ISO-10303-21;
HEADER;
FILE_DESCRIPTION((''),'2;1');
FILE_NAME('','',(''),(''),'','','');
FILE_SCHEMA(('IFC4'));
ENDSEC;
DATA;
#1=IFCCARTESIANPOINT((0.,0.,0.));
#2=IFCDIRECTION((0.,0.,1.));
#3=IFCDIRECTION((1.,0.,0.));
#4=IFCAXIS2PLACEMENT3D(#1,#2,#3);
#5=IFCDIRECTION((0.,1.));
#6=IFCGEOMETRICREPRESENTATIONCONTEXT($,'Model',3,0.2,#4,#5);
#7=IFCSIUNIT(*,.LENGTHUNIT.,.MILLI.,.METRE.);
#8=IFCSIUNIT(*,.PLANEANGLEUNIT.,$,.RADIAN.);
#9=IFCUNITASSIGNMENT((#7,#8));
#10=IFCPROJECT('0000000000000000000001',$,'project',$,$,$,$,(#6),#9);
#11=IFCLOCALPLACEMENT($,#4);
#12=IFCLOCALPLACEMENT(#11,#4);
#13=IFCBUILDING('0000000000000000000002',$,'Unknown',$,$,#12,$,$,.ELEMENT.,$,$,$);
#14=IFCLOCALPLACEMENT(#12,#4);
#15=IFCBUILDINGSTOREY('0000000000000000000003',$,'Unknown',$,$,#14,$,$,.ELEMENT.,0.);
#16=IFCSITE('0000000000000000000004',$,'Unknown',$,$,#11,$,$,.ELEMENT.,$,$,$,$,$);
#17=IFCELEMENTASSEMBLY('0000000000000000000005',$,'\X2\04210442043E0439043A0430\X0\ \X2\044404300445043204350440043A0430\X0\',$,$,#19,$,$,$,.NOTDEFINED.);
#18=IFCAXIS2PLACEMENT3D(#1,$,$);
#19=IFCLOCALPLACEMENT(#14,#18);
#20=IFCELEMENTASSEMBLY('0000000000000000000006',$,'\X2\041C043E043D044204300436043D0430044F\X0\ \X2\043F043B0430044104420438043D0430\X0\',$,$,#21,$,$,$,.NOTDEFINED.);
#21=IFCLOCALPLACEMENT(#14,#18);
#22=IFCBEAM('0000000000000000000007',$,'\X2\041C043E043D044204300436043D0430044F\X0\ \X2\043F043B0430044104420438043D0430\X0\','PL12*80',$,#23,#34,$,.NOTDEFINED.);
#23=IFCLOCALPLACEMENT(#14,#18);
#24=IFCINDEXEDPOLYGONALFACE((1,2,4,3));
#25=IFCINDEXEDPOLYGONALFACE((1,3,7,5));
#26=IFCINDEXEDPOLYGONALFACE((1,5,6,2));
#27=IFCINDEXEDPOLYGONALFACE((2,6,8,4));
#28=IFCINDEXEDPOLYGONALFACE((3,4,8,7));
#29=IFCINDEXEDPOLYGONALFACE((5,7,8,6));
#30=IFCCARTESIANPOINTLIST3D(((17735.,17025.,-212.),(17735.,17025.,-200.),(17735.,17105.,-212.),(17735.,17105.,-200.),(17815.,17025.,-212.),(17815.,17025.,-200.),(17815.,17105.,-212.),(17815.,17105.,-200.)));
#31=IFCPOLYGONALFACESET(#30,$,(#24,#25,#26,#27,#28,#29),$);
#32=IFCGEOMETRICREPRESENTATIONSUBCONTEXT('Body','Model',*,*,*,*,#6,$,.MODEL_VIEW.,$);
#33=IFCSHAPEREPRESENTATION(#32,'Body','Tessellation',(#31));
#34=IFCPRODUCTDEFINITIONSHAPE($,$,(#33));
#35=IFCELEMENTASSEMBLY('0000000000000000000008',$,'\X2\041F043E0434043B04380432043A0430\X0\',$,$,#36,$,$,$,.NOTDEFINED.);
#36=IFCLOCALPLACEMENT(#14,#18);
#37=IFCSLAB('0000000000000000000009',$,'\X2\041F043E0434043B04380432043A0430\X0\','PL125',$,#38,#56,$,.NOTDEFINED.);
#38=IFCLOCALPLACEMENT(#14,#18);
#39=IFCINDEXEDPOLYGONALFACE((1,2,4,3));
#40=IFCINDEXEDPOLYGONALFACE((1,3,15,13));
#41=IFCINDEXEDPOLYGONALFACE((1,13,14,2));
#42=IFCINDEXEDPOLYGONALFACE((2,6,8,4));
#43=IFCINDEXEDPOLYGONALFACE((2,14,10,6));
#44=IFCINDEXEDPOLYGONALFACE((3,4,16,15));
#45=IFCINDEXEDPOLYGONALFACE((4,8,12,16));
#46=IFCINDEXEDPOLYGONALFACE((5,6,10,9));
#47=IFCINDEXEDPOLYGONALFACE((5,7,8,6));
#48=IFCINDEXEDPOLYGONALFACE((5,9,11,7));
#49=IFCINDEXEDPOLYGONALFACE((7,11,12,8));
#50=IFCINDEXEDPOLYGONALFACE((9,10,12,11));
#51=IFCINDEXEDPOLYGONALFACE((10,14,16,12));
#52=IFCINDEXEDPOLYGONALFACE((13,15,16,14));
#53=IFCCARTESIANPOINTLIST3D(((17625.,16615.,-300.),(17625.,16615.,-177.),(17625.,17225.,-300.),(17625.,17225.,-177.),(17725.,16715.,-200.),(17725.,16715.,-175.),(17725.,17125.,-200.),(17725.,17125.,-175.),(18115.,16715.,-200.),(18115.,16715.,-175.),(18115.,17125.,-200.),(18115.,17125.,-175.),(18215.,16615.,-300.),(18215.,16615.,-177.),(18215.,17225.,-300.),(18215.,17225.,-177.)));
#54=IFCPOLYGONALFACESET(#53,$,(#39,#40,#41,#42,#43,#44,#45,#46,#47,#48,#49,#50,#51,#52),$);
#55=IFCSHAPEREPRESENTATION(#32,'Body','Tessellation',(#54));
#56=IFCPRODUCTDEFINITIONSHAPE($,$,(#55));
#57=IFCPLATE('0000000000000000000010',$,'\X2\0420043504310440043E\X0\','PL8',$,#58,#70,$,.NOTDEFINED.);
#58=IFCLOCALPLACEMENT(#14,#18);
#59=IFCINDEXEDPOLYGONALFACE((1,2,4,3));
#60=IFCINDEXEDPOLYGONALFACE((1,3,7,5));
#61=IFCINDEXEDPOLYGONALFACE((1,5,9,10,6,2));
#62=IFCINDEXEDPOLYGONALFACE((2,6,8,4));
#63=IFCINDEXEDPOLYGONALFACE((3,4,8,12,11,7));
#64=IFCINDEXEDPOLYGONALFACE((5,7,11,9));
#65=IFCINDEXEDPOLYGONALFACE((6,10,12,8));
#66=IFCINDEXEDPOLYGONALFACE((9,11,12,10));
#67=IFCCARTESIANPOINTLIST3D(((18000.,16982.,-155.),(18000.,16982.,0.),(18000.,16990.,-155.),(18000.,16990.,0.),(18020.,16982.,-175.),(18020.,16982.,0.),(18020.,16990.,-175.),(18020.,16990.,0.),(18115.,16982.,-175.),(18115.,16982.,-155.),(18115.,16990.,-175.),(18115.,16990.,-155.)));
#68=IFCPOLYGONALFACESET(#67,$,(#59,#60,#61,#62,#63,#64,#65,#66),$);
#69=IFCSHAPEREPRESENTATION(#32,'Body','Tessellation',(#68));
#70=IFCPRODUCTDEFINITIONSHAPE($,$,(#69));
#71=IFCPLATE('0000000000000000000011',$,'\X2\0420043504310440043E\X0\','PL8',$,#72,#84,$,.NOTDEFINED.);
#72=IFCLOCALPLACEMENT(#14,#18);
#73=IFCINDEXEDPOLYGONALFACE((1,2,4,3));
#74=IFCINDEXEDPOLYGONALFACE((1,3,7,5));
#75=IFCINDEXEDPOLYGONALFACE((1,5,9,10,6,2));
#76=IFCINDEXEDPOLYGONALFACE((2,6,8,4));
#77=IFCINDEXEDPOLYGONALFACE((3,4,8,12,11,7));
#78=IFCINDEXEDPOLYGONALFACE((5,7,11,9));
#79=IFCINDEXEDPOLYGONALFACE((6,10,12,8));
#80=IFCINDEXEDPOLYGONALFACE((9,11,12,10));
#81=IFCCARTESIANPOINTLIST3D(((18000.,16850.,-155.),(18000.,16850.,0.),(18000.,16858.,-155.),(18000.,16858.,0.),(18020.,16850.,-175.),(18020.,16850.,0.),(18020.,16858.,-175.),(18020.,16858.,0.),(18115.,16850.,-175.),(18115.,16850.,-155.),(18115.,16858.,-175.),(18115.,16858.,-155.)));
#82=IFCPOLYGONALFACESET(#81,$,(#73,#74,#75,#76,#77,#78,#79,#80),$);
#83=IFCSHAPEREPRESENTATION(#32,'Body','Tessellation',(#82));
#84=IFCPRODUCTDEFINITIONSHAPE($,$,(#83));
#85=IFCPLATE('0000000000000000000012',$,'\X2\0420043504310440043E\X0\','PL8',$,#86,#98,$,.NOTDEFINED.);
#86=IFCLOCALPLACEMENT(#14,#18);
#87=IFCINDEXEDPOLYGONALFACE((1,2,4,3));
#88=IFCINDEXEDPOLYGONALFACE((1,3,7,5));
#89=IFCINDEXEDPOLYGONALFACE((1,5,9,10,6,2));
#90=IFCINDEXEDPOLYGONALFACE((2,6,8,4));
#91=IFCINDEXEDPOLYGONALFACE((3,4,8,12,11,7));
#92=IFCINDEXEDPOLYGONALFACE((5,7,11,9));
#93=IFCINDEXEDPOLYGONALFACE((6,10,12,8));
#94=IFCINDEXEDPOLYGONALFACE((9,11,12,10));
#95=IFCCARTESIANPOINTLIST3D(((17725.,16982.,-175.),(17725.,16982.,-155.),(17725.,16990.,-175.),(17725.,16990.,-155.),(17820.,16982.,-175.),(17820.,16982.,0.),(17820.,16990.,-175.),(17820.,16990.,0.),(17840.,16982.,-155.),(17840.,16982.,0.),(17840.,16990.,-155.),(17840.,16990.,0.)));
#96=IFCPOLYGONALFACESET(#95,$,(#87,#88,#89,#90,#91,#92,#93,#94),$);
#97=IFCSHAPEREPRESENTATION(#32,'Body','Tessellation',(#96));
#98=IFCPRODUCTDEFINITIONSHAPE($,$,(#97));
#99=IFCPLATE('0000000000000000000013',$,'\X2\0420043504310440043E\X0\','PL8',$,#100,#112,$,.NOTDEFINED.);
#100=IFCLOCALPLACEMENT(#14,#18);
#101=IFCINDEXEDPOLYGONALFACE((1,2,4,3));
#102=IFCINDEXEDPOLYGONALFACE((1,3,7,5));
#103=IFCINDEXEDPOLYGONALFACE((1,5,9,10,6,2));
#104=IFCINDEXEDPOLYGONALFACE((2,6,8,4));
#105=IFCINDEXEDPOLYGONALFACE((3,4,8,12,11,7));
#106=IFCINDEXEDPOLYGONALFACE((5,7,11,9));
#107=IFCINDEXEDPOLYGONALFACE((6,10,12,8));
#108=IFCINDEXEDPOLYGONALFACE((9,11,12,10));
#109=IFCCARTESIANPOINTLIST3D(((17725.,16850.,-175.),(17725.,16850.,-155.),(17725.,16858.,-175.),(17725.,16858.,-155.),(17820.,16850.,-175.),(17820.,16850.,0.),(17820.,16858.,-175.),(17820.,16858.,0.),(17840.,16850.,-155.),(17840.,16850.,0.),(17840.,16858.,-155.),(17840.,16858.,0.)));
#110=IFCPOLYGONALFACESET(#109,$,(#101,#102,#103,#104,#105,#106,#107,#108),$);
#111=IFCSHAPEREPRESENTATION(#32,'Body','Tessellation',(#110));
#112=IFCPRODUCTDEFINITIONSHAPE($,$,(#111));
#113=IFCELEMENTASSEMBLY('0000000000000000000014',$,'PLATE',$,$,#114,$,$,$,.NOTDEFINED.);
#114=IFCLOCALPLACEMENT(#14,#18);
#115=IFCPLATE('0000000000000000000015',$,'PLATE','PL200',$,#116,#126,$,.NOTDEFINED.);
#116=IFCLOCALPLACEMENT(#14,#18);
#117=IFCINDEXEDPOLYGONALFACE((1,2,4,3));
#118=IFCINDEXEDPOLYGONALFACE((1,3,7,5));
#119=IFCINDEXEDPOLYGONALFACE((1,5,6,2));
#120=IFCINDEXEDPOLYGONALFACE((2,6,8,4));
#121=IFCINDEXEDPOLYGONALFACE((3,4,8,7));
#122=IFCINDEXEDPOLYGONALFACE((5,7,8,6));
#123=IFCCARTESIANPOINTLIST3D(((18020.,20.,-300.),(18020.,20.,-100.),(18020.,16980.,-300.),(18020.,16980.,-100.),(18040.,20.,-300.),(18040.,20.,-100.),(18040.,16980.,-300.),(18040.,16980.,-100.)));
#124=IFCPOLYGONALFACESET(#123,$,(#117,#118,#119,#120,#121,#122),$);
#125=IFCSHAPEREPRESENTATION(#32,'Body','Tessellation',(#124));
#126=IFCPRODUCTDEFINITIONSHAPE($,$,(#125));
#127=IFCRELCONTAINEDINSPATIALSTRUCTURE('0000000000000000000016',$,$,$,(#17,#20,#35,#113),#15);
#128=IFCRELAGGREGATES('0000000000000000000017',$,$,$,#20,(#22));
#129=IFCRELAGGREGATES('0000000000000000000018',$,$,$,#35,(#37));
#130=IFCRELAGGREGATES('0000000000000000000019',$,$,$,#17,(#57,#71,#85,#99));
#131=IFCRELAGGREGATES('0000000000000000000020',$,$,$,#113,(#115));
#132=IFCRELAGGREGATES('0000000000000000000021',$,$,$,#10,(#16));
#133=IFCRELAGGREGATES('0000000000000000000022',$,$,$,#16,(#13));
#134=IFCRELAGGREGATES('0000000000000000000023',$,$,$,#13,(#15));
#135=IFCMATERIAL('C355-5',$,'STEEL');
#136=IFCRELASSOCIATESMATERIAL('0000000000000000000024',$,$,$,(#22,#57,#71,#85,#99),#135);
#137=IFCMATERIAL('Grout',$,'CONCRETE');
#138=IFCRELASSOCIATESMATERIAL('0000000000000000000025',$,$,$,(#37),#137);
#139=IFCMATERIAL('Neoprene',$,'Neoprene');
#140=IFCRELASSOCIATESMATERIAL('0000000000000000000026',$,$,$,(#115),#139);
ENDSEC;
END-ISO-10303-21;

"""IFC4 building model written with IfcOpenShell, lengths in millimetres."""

from ifc_helpers import new_model, si_unit, direction, frame, origin_with_axes, place, context, subcontext, project, spatial, line, indexed_curve, outline, extrude, material, element, aggregate, save


model = new_model("IFC4")

# Units and contexts
model_context = context("Model", 3, precision=0.2, world=origin_with_axes(), true_north=direction((0.0, 1.0)))
body_context = subcontext(model_context, "Body", "Model", "MODEL_VIEW")
ifc_project = project(units=[si_unit("LENGTHUNIT", "METRE", prefix="MILLI"), si_unit("PLANEANGLEUNIT", "RADIAN")], contexts=[model_context])

# Site, building, storey
site_placement = place(None, origin_with_axes())
site = spatial("IfcSite", under=ifc_project, at=site_placement, Name="Unknown", CompositionType="ELEMENT")
building_placement = place(site_placement, origin_with_axes())
building = spatial("IfcBuilding", under=site, at=building_placement, Name="Unknown", CompositionType="ELEMENT")
storey_placement = place(building_placement, origin_with_axes())
storey = spatial("IfcBuildingStorey", under=building, at=storey_placement, Name="Unknown", CompositionType="ELEMENT", Elevation=0.0)

# Shared definitions
ifc_material_1 = material(Name="C355-5", Category="STEEL")

# Element assembly
assembly_1_placement = place(storey_placement, frame((17920.0, 16920.0, -200.0), z_axis=(0.0, -1.0, 0.0), x_axis=(0.0, 0.0, 1.0)))
assembly_1 = element("IfcElementAssembly", 1, at=assembly_1_placement, inside=storey, Name="Стойка фахверка", PredefinedType="NOTDEFINED")

# Element assembly, beam
assembly_2_placement = place(storey_placement, frame((17735.0, 17065.0, -206.0), z_axis=(0.0, 0.0, -1.0), x_axis=(1.0, 0.0, 0.0)))
assembly_2 = element("IfcElementAssembly", 2, at=assembly_2_placement, inside=storey, Name="Монтажная пластина", PredefinedType="NOTDEFINED")
beam_1_placement = place(assembly_2_placement, origin_with_axes())
beam_1 = element("IfcBeam", 3, at=beam_1_placement, material=ifc_material_1, Name="Монтажная пластина", Description="PL12*80", PredefinedType="NOTDEFINED", context=body_context, shape_type="SolidModel", body=[
    extrude(outline(indexed_curve([(-6.0, -40.0), (6.0, -40.0), (6.0, 40.0), (-6.0, 40.0)], segments=[line(1, 2, 3, 4, 1)])), frame((0.0, 0.0, 0.0), z_axis=(-1.0, 0.0, 0.0), x_axis=(0.0, 0.0, 1.0)), (0.0, 0.0, -1.0), 80.0),
])
aggregate(assembly_2, [beam_1])

# Element assembly, slab, voiding features
assembly_3_placement = place(storey_placement, frame((18215.0, 16615.0, -237.5), z_axis=(0.0, 0.0, -1.0), x_axis=(-1.0, 0.0, 0.0)))
assembly_3 = element("IfcElementAssembly", 4, at=assembly_3_placement, inside=storey, Name="Подливка", PredefinedType="NOTDEFINED")
ifc_material_2 = material(Name="Grout", Category="CONCRETE")
slab_placement = place(assembly_3_placement, origin_with_axes())
slab = element("IfcSlab", 5, at=slab_placement, material=ifc_material_2, Name="Подливка", Description="PL125", PredefinedType="NOTDEFINED", context=body_context, shape_type="SolidModel", body=[
    extrude(outline(indexed_curve([(0.0, 0.0), (590.0, 0.0), (590.0, 610.0), (0.0, 610.0)], segments=[line(1, 2, 3, 4, 1)])), frame((0.0, 0.0, 62.5), z_axis=(0.0, 0.0, 1.0), x_axis=(1.0, 0.0, 0.0)), (0.0, 0.0, -1.0), 125.0),
])
voiding_feature_1_placement = place(slab_placement, frame((295.0, 0.0, -62.5), z_axis=(1.0, 0.0, 0.0), x_axis=(0.0, 1.0, 0.0)))
element("IfcVoidingFeature", 6, at=voiding_feature_1_placement, cuts=slab, Name="PLATE", PredefinedType="HOLE", context=body_context, shape_type="SolidModel", body=[
    extrude(outline(indexed_curve([(0.0, 0.0), (100.0, 0.0), (0.0, 2.0)], segments=[line(1, 2, 3, 1)])), frame((0.0, 0.0, 307.0), z_axis=(0.0, 0.0, 1.0), x_axis=(1.0, 0.0, 0.0)), (0.0, 0.0, -1.0), 614.0),
])
voiding_feature_2_placement = place(slab_placement, frame((295.0, 610.0, -62.5), z_axis=(-1.0, 0.0, 0.0), x_axis=(0.0, -1.0, 0.0)))
element("IfcVoidingFeature", 7, at=voiding_feature_2_placement, cuts=slab, Name="PLATE", PredefinedType="HOLE", context=body_context, shape_type="SolidModel", body=[
    extrude(outline(indexed_curve([(0.0, 0.0), (100.0, 0.0), (0.0, 2.0)], segments=[line(1, 2, 3, 1)])), frame((0.0, 0.0, 307.0), z_axis=(0.0, 0.0, 1.0), x_axis=(1.0, 0.0, 0.0)), (0.0, 0.0, -1.0), 614.0),
])
voiding_feature_3_placement = place(slab_placement, frame((590.0, 305.0, -62.5), z_axis=(0.0, 1.0, 0.0), x_axis=(-1.0, 0.0, 0.0)))
element("IfcVoidingFeature", 8, at=voiding_feature_3_placement, cuts=slab, Name="PLATE", PredefinedType="HOLE", context=body_context, shape_type="SolidModel", body=[
    extrude(outline(indexed_curve([(0.0, 0.0), (100.0, 0.0), (0.0, 2.0)], segments=[line(1, 2, 3, 1)])), frame((0.0, 0.0, 317.0), z_axis=(0.0, 0.0, 1.0), x_axis=(1.0, 0.0, 0.0)), (0.0, 0.0, -1.0), 634.0),
])
voiding_feature_4_placement = place(slab_placement, frame((0.0, 305.0, -62.5), z_axis=(0.0, -1.0, 0.0), x_axis=(1.0, 0.0, 0.0)))
element("IfcVoidingFeature", 9, at=voiding_feature_4_placement, cuts=slab, Name="PLATE", PredefinedType="HOLE", context=body_context, shape_type="SolidModel", body=[
    extrude(outline(indexed_curve([(0.0, 0.0), (100.0, 0.0), (0.0, 2.0)], segments=[line(1, 2, 3, 1)])), frame((0.0, 0.0, 317.0), z_axis=(0.0, 0.0, 1.0), x_axis=(1.0, 0.0, 0.0)), (0.0, 0.0, -1.0), 634.0),
])
voiding_feature_5_placement = place(slab_placement, frame((295.0, 510.0, -50.0), z_axis=(0.0, 0.0, 1.0), x_axis=(0.0, -1.0, 0.0)))
element("IfcVoidingFeature", 10, at=voiding_feature_5_placement, cuts=slab, Name="Пластина", PredefinedType="HOLE", context=body_context, shape_type="SolidModel", body=[
    extrude(outline(indexed_curve([(-12.5, -195.0), (12.5, -195.0), (12.5, 195.0), (-12.5, 195.0)], segments=[line(1, 2, 3, 4, 1)])), frame((0.0, 0.0, 0.0), z_axis=(-1.0, 0.0, 0.0), x_axis=(0.0, 0.0, 1.0)), (0.0, 0.0, -1.0), 410.0),
])
aggregate(assembly_3, [slab])

# Plates
plate_1_placement = place(assembly_1_placement, frame((25.0, -80.0, -66.0), z_axis=(0.0, 0.0, 1.0), x_axis=(0.0, -1.0, 0.0)))
plate_1 = element("IfcPlate", 11, at=plate_1_placement, material=ifc_material_1, Name="Ребро", Description="PL8", PredefinedType="NOTDEFINED", context=body_context, shape_type="SolidModel", body=[
    extrude(outline(indexed_curve([(0.0, 20.0), (20.0, 0.0), (115.0, 0.0), (115.0, 20.0), (20.0, 175.0), (0.0, 175.0)], segments=[line(1, 2, 3, 4, 5, 6, 1)])), frame((0.0, 0.0, 4.0), z_axis=(0.0, 0.0, 1.0), x_axis=(1.0, 0.0, 0.0)), (0.0, 0.0, -1.0), 8.0),
])
plate_2_placement = place(assembly_1_placement, frame((25.0, -80.0, 66.0), z_axis=(0.0, 0.0, 1.0), x_axis=(0.0, -1.0, 0.0)))
plate_2 = element("IfcPlate", 12, at=plate_2_placement, material=ifc_material_1, Name="Ребро", Description="PL8", PredefinedType="NOTDEFINED", context=body_context, shape_type="SolidModel", body=[
    extrude(outline(indexed_curve([(0.0, 20.0), (20.0, 0.0), (115.0, 0.0), (115.0, 20.0), (20.0, 175.0), (0.0, 175.0)], segments=[line(1, 2, 3, 4, 5, 6, 1)])), frame((0.0, 0.0, 4.0), z_axis=(0.0, 0.0, 1.0), x_axis=(1.0, 0.0, 0.0)), (0.0, 0.0, -1.0), 8.0),
])
plate_3_placement = place(assembly_1_placement, frame((25.0, 195.0, -66.0), z_axis=(0.0, 0.0, 1.0), x_axis=(0.0, -1.0, 0.0)))
plate_3 = element("IfcPlate", 13, at=plate_3_placement, material=ifc_material_1, Name="Ребро", Description="PL8", PredefinedType="NOTDEFINED", context=body_context, shape_type="SolidModel", body=[
    extrude(outline(indexed_curve([(0.0, 0.0), (95.0, 0.0), (115.0, 20.0), (115.0, 175.0), (95.0, 175.0), (0.0, 20.0)], segments=[line(1, 2, 3, 4, 5, 6, 1)])), frame((0.0, 0.0, 4.0), z_axis=(0.0, 0.0, 1.0), x_axis=(1.0, 0.0, 0.0)), (0.0, 0.0, -1.0), 8.0),
])
plate_4_placement = place(assembly_1_placement, frame((25.0, 195.0, 66.0), z_axis=(0.0, 0.0, 1.0), x_axis=(0.0, -1.0, 0.0)))
plate_4 = element("IfcPlate", 14, at=plate_4_placement, material=ifc_material_1, Name="Ребро", Description="PL8", PredefinedType="NOTDEFINED", context=body_context, shape_type="SolidModel", body=[
    extrude(outline(indexed_curve([(0.0, 0.0), (95.0, 0.0), (115.0, 20.0), (115.0, 175.0), (95.0, 175.0), (0.0, 20.0)], segments=[line(1, 2, 3, 4, 5, 6, 1)])), frame((0.0, 0.0, 4.0), z_axis=(0.0, 0.0, 1.0), x_axis=(1.0, 0.0, 0.0)), (0.0, 0.0, -1.0), 8.0),
])
aggregate(assembly_1, [plate_1, plate_2, plate_3, plate_4])

# Element assembly, plate
assembly_4_placement = place(storey_placement, frame((20.0, 16980.0, -200.0), z_axis=(0.0, 0.0, 1.0), x_axis=(0.0, -1.0, 0.0)))
assembly_4 = element("IfcElementAssembly", 15, at=assembly_4_placement, inside=storey, Name="PLATE", PredefinedType="NOTDEFINED")
ifc_material_3 = material(Name="Neoprene", Category="Neoprene")
plate_5_placement = place(assembly_4_placement, frame((0.0, 18000.0, 0.0), z_axis=(0.0, 0.0, 1.0), x_axis=(1.0, 0.0, 0.0)))
plate_5 = element("IfcPlate", 16, at=plate_5_placement, material=ifc_material_3, Name="PLATE", Description="PL200", PredefinedType="NOTDEFINED", context=body_context, shape_type="SolidModel", body=[
    extrude(outline(indexed_curve([(0.0, 0.0), (16960.0, 0.0), (16960.0, 20.0), (0.0, 20.0)], segments=[line(1, 2, 3, 4, 1)])), frame((0.0, 0.0, 100.0), z_axis=(0.0, 0.0, 1.0), x_axis=(1.0, 0.0, 0.0)), (0.0, 0.0, -1.0), 200.0),
])
aggregate(assembly_4, [plate_5])

save(model, "model.ifc")
